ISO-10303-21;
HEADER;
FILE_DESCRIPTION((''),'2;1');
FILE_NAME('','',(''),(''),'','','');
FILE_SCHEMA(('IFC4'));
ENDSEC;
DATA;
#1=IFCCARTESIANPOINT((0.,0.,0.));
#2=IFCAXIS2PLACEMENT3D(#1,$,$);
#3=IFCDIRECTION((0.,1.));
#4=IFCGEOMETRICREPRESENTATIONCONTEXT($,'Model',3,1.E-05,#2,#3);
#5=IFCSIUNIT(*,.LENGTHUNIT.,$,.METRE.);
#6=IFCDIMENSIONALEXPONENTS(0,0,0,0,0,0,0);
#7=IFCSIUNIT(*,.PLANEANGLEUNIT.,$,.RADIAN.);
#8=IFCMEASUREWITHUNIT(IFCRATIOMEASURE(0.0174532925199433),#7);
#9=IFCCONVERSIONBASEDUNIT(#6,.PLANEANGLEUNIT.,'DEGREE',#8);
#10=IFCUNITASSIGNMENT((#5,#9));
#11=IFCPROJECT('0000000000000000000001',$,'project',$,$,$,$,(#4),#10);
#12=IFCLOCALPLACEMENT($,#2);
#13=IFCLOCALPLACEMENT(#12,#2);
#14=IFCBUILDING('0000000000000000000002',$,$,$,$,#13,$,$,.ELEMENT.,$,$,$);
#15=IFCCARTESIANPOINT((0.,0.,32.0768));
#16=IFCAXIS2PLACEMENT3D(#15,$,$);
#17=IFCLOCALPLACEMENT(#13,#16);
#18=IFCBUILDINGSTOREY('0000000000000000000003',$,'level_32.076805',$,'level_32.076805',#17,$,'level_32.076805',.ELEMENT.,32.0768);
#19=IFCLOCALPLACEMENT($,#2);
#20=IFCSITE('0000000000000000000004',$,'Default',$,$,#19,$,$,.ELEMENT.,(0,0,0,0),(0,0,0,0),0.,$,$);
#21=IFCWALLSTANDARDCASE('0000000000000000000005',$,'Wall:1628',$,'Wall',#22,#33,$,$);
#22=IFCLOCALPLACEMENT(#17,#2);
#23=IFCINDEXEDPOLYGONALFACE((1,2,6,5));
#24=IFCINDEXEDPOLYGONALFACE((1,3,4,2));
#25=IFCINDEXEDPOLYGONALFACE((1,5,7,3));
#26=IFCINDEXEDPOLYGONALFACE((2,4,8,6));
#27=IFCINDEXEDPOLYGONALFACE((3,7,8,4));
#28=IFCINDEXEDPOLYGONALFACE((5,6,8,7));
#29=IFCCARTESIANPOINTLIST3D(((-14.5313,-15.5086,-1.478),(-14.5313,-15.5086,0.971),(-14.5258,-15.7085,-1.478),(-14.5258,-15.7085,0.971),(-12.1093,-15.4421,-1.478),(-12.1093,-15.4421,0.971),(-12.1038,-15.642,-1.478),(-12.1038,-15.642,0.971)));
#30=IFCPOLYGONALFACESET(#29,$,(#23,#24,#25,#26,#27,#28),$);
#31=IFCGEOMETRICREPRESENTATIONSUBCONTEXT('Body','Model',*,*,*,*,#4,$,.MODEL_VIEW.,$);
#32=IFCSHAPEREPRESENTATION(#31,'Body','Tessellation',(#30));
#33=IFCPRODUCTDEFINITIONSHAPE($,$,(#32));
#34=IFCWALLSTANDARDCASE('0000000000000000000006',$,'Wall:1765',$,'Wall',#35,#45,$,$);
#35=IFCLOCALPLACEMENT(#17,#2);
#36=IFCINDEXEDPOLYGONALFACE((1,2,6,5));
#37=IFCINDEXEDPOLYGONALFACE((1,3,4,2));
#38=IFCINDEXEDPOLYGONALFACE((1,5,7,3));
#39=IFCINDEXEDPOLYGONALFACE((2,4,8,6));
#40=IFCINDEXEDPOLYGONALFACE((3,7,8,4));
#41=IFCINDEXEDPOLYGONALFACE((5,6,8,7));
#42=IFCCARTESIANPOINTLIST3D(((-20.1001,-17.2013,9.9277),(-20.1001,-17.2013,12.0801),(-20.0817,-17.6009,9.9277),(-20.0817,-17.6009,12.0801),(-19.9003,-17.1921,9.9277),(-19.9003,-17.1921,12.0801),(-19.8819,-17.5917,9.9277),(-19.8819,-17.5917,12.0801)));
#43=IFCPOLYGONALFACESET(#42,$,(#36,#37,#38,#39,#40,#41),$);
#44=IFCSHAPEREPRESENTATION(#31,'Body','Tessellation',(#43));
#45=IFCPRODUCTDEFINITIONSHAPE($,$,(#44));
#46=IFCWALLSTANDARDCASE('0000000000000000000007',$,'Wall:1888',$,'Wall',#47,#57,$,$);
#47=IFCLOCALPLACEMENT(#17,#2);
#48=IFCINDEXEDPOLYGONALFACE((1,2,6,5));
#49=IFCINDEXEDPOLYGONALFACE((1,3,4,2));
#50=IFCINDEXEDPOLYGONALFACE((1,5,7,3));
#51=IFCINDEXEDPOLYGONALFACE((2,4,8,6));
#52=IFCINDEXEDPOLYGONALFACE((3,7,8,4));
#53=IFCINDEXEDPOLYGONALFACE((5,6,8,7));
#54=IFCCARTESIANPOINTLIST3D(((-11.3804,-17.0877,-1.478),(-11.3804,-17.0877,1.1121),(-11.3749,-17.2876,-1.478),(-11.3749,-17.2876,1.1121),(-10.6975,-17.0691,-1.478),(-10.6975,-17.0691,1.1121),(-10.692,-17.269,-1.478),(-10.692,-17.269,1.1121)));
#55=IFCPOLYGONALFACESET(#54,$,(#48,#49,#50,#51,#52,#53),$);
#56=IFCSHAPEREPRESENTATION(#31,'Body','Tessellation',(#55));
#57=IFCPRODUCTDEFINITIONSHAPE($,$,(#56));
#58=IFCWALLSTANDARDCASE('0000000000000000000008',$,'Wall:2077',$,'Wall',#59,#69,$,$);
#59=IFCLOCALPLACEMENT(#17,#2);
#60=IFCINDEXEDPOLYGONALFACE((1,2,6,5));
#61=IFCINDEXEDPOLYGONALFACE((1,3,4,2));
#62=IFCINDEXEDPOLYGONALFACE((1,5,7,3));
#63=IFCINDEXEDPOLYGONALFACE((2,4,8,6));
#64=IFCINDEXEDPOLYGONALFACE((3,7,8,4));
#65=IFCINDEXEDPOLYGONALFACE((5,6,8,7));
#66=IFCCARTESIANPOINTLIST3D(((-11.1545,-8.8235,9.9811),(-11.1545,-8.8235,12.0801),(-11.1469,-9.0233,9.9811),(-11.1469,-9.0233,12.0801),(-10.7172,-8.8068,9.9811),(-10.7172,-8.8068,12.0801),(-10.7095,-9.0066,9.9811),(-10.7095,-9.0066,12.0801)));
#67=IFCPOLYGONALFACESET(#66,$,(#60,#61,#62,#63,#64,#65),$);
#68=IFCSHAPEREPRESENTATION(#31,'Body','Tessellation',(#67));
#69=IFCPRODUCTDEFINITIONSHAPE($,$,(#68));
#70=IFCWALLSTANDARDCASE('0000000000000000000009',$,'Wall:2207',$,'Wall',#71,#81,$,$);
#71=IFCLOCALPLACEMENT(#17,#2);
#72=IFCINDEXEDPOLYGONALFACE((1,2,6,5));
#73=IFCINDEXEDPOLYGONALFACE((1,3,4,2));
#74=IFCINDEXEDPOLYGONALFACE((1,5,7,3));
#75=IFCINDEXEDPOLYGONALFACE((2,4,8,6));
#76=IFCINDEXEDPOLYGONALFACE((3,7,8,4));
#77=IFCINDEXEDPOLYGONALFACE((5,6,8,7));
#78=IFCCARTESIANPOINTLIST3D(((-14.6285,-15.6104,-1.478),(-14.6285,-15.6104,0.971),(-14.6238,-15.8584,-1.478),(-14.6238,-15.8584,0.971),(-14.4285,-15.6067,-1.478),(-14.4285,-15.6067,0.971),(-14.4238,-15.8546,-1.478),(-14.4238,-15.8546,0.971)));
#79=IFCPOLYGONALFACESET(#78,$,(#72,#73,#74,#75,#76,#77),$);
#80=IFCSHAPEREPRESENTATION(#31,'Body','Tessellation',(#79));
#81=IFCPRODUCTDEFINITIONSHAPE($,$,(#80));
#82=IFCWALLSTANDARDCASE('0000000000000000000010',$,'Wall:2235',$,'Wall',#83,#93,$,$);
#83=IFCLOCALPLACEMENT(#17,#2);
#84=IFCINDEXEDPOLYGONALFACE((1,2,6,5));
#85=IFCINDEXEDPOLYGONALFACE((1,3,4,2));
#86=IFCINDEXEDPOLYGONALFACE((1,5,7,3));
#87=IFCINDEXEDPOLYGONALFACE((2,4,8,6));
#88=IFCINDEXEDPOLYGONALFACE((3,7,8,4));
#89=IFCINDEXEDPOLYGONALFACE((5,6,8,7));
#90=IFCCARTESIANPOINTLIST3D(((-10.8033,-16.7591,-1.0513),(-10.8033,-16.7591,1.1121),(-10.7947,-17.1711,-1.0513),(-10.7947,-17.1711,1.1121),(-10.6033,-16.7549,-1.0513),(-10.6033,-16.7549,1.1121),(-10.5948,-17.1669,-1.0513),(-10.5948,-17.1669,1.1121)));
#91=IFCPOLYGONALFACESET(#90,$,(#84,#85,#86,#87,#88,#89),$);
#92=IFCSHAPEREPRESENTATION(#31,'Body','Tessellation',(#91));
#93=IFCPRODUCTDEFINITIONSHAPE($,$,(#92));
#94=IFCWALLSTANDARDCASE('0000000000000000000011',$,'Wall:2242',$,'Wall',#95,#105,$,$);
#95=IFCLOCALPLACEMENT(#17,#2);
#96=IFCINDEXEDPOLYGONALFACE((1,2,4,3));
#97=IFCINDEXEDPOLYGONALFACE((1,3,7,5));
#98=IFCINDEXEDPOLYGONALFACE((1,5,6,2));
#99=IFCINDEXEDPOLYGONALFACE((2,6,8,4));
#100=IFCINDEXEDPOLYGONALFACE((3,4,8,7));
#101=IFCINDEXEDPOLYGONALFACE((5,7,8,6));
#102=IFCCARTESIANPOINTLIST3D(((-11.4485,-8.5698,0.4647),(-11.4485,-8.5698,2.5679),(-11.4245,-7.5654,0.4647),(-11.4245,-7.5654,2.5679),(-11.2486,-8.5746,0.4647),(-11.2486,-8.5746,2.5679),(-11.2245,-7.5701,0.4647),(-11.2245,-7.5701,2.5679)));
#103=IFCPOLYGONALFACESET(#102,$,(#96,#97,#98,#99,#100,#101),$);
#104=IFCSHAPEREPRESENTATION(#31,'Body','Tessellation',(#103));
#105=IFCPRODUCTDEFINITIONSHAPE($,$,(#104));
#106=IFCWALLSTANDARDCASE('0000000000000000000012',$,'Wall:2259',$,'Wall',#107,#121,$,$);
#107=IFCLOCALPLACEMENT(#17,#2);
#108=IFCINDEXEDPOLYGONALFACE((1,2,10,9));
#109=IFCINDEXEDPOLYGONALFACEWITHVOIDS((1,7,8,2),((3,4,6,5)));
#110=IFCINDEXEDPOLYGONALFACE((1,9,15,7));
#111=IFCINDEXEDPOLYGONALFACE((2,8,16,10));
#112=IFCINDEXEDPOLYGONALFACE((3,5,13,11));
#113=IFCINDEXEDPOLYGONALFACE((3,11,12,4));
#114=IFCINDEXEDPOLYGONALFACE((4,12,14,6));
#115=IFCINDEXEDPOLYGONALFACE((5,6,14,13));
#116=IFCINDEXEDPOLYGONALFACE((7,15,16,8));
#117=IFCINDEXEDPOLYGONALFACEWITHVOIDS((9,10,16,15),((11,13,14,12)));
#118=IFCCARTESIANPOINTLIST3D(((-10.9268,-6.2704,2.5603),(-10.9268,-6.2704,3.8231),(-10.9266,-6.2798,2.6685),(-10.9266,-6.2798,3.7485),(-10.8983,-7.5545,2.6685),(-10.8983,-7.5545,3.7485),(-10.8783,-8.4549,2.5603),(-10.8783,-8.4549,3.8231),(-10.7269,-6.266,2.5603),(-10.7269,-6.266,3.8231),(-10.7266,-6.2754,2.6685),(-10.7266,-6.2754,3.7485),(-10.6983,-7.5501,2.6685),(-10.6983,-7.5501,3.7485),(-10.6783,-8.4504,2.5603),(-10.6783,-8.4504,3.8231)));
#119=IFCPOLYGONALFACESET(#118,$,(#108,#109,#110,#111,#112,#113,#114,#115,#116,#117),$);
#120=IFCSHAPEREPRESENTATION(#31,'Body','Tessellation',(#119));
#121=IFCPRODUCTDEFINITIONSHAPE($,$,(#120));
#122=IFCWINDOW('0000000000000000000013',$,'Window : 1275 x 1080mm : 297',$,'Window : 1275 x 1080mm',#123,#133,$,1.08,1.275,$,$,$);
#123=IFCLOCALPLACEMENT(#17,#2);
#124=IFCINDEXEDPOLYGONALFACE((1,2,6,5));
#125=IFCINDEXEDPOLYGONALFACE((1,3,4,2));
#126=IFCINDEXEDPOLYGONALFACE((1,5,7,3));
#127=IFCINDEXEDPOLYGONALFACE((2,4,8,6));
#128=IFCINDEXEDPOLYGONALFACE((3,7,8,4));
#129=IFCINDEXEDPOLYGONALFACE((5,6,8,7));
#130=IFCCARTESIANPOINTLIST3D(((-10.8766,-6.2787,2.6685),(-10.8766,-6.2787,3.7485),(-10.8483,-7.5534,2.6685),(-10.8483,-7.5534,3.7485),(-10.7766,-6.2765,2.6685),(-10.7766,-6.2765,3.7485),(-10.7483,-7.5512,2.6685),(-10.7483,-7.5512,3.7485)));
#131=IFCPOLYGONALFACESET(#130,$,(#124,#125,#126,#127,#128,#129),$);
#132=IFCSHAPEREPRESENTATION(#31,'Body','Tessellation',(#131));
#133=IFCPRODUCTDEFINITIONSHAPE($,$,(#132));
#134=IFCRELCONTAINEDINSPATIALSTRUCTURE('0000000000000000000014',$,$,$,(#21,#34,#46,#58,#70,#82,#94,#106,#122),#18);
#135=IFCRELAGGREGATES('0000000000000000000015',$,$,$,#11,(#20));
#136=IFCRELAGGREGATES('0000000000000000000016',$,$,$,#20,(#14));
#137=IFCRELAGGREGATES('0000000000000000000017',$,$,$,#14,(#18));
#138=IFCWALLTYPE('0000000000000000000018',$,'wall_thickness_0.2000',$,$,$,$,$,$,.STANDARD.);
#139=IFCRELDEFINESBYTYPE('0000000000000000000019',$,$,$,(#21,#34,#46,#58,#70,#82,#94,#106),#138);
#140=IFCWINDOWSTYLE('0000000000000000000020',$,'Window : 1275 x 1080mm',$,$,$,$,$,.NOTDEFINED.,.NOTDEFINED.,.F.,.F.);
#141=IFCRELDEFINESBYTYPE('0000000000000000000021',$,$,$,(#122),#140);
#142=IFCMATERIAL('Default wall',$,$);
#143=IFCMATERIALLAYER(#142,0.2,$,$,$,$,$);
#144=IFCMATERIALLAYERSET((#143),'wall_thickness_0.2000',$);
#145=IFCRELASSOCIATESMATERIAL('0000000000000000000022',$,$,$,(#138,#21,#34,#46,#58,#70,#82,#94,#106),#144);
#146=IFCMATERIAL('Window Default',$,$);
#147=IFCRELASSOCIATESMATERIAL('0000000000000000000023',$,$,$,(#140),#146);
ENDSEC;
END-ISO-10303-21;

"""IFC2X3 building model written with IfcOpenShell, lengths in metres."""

from ifc_helpers import new_model, entity, si_unit, converted_unit, direction, frame, frame_2d, origin, origin_2d_with_axis, place, context, subcontext, project, spatial, polyline, rectangle, outline, extrude, source, transform, mapped, material, layer, layer_set, layer_usage, type_object, type_shapes, element, fill, save


model = new_model("IFC2X3")

# Units and contexts
model_context = context("Model", 3, precision=1e-05, world=origin(), true_north=direction((0.0, 1.0)))
body_context = subcontext(model_context, "Body", "Model", "MODEL_VIEW")
ifc_project = project(units=[si_unit("LENGTHUNIT", "METRE"), converted_unit("PLANEANGLEUNIT", "DEGREE", entity("IfcRatioMeasure", 0.0174532925199433), si_unit("PLANEANGLEUNIT", "RADIAN"), dimensions=[0, 0, 0, 0, 0, 0, 0])], contexts=[model_context])

# Site, building, storey
site_placement = place(None, origin())
site = spatial("IfcSite", under=ifc_project, at=site_placement, Name="Default", CompositionType="ELEMENT", RefLatitude=(0, 0, 0, 0), RefLongitude=(0, 0, 0, 0), RefElevation=0.0)
placement_1 = place(None, origin())
building_placement = place(placement_1, origin())
building = spatial("IfcBuilding", under=site, at=building_placement, CompositionType="ELEMENT")
storey_placement = place(building_placement, frame((0.0, 0.0, 32.0768)))
storey = spatial("IfcBuildingStorey", under=building, at=storey_placement, Name="level_32.076805", ObjectType="level_32.076805", LongName="level_32.076805", CompositionType="ELEMENT", Elevation=32.0768)

# Shared definitions
ifc_material_1 = material(Name="Default wall")
ifc_layer = layer(ifc_material_1, 0.2)
ifc_layer_set = layer_set([ifc_layer], Name="wall_thickness_0.2000")
ifc_layer_usage = layer_usage(ifc_layer_set, "AXIS2", "POSITIVE", -0.1)
wall_type = type_object("IfcWallType", Name="wall_thickness_0.2000", PredefinedType="STANDARD", material=ifc_layer_set)

# Shared definitions
ifc_material_2 = material(Name="Window Default")

# Walls
placement_2 = place(building_placement, frame((0.0, 0.0, 30.5988)))
wall_1_placement = place(placement_2, frame((-12.1065, -15.542, 0.0), z_axis=(0.0, 0.0, 1.0), x_axis=(-0.999623, -0.027447, 0.0)))
element("IfcWallStandardCase", 1, at=wall_1_placement, inside=storey, type_object=wall_type, material=ifc_layer_usage, Name="Wall:1628", ObjectType="Wall", context=body_context, shape_type="SweptSolid", body=[
    extrude(outline(polyline([(2.4229, -0.1), (2.4229, 0.1), (0.0, 0.1), (0.0, -0.1), (2.4229, -0.1)])), origin(), (0.0, 0.0, 1.0), 2.449),
])
placement_3 = place(building_placement, frame((0.0, 0.0, 42.0045)))
wall_2_placement = place(placement_3, frame((-20.0002, -17.1967, 0.0), z_axis=(0.0, 0.0, 1.0), x_axis=(0.046029, -0.99894, 0.0)))
element("IfcWallStandardCase", 2, at=wall_2_placement, inside=storey, type_object=wall_type, material=ifc_layer_usage, Name="Wall:1765", ObjectType="Wall", context=body_context, shape_type="SweptSolid", body=[
    extrude(outline(polyline([(0.4, -0.1), (0.4, 0.1), (0.0, 0.1), (0.0, -0.1), (0.4, -0.1)])), origin(), (0.0, 0.0, 1.0), 2.1524),
])
placement_4 = place(building_placement, frame((0.0, 0.0, 30.5988)))
wall_3_placement = place(placement_4, frame((-10.6948, -17.169, 0.0), z_axis=(0.0, 0.0, 1.0), x_axis=(-0.999627, -0.027308, 0.0)))
element("IfcWallStandardCase", 3, at=wall_3_placement, inside=storey, type_object=wall_type, material=ifc_layer_usage, Name="Wall:1888", ObjectType="Wall", context=body_context, shape_type="SweptSolid", body=[
    extrude(outline(polyline([(0.6832, -0.1), (0.6832, 0.1), (0.0, 0.1), (0.0, -0.1), (0.6832, -0.1)])), origin(), (0.0, 0.0, 1.0), 2.5901),
])
placement_5 = place(building_placement, frame((0.0, 0.0, 42.0579)))
wall_4_placement = place(placement_5, frame((-10.7133, -8.9067, 0.0), z_axis=(0.0, 0.0, 1.0), x_axis=(-0.999271, -0.038174, 0.0)))
element("IfcWallStandardCase", 4, at=wall_4_placement, inside=storey, type_object=wall_type, material=ifc_layer_usage, Name="Wall:2077", ObjectType="Wall", context=body_context, shape_type="SweptSolid", body=[
    extrude(outline(polyline([(0.4377, -0.1), (0.4377, 0.1), (0.0, 0.1), (0.0, -0.1), (0.4377, -0.1)])), origin(), (0.0, 0.0, 1.0), 2.099),
])
placement_6 = place(building_placement, frame((0.0, 0.0, 30.5988)))
wall_5_placement = place(placement_6, frame((-14.5238, -15.8565, 0.0), z_axis=(0.0, 0.0, 1.0), x_axis=(-0.018983, 0.99982, 0.0)))
element("IfcWallStandardCase", 5, at=wall_5_placement, inside=storey, type_object=wall_type, material=ifc_layer_usage, Name="Wall:2207", ObjectType="Wall", context=body_context, shape_type="SweptSolid", body=[
    extrude(outline(polyline([(0.248, -0.1), (0.248, 0.1), (0.0, 0.1), (0.0, -0.1), (0.248, -0.1)])), origin(), (0.0, 0.0, 1.0), 2.449),
])
placement_7 = place(building_placement, frame((0.0, 0.0, 31.0255)))
wall_6_placement = place(placement_7, frame((-10.7033, -16.757, 0.0), z_axis=(0.0, 0.0, 1.0), x_axis=(0.020684, -0.999786, 0.0)))
element("IfcWallStandardCase", 6, at=wall_6_placement, inside=storey, type_object=wall_type, material=ifc_layer_usage, Name="Wall:2235", ObjectType="Wall", context=body_context, shape_type="SweptSolid", body=[
    extrude(outline(polyline([(0.4121, -0.1), (0.4121, 0.1), (0.0, 0.1), (0.0, -0.1), (0.4121, -0.1)])), origin(), (0.0, 0.0, 1.0), 2.1634),
])
placement_8 = place(building_placement, frame((0.0, 0.0, 32.5415)))
wall_7_placement = place(placement_8, frame((-11.3485, -8.5722, 0.0), z_axis=(0.0, 0.0, 1.0), x_axis=(0.023904, 0.999714, 0.0)))
element("IfcWallStandardCase", 7, at=wall_7_placement, inside=storey, type_object=wall_type, material=ifc_layer_usage, Name="Wall:2242", ObjectType="Wall", context=body_context, shape_type="SweptSolid", body=[
    extrude(outline(polyline([(1.0047, -0.1), (1.0047, 0.1), (0.0, 0.1), (0.0, -0.1), (1.0047, -0.1)])), origin(), (0.0, 0.0, 1.0), 2.1031),
])

# Wall, opening, window
placement_9 = place(building_placement, frame((0.0, 0.0, 34.6371)))
wall_8_placement = place(placement_9, frame((-10.7783, -8.4527, 0.0), z_axis=(0.0, 0.0, 1.0), x_axis=(-0.022207, 0.999753, 0.0)))
wall_8 = element("IfcWallStandardCase", 8, at=wall_8_placement, inside=storey, type_object=wall_type, material=ifc_layer_usage, Name="Wall:2259", ObjectType="Wall", context=body_context, shape_type="SweptSolid", body=[
    extrude(outline(polyline([(2.185, -0.1), (2.185, 0.1), (0.0, 0.1), (0.0, -0.1), (2.185, -0.1)])), origin(), (0.0, 0.0, 1.0), 1.2628),
])
opening_1_placement = place(wall_8_placement, frame((0.9006, -0.1, 0.1083)))
opening_1 = element("IfcOpeningElement", 9, at=opening_1_placement, cuts=wall_8, ObjectType="Opening", context=body_context, shape_type="SweptSolid", body=[
    extrude(rectangle(XDim=1.275, YDim=1.08, at=frame_2d((0.54, 0.6375), x_axis=(0.0, 1.0))), frame((0.0, 0.0, 0.0), z_axis=(0.0, 1.0, 0.0), x_axis=(0.0, 0.0, 1.0)), (0.0, 0.0, 1.0), 0.2),
])
window_style_1 = type_object("IfcWindowStyle", Name="Window : 1275 x 1080mm", ConstructionType="NOTDEFINED", OperationType="NOTDEFINED", ParameterTakesPrecedence=False, Sizeable=False, material=ifc_material_2)
shared_shape_1 = source(origin(), body_context, "Body", "SweptSolid", [
    extrude(rectangle(XDim=0.1, YDim=1.275, at=origin_2d_with_axis()), frame((0.6375, 0.1, 0.0), z_axis=(0.0, 0.0, 1.0), x_axis=(0.0, 1.0, 0.0)), (0.0, 0.0, 1.0), 1.08),
])
type_shapes(window_style_1, [shared_shape_1])
window_1_placement = place(opening_1_placement, origin())
window_1 = element("IfcWindow", 10, at=window_1_placement, inside=storey, type_object=window_style_1, Name="Window : 1275 x 1080mm : 297", ObjectType="Window : 1275 x 1080mm", OverallHeight=1.08, OverallWidth=1.275, context=body_context, shape_type="MappedRepresentation", body=[
    mapped(shared_shape_1, transform((0.0, 0.0, 0.0), scale=1.0)),
])
fill(opening_1, window_1)

save(model, "model.ifc")
